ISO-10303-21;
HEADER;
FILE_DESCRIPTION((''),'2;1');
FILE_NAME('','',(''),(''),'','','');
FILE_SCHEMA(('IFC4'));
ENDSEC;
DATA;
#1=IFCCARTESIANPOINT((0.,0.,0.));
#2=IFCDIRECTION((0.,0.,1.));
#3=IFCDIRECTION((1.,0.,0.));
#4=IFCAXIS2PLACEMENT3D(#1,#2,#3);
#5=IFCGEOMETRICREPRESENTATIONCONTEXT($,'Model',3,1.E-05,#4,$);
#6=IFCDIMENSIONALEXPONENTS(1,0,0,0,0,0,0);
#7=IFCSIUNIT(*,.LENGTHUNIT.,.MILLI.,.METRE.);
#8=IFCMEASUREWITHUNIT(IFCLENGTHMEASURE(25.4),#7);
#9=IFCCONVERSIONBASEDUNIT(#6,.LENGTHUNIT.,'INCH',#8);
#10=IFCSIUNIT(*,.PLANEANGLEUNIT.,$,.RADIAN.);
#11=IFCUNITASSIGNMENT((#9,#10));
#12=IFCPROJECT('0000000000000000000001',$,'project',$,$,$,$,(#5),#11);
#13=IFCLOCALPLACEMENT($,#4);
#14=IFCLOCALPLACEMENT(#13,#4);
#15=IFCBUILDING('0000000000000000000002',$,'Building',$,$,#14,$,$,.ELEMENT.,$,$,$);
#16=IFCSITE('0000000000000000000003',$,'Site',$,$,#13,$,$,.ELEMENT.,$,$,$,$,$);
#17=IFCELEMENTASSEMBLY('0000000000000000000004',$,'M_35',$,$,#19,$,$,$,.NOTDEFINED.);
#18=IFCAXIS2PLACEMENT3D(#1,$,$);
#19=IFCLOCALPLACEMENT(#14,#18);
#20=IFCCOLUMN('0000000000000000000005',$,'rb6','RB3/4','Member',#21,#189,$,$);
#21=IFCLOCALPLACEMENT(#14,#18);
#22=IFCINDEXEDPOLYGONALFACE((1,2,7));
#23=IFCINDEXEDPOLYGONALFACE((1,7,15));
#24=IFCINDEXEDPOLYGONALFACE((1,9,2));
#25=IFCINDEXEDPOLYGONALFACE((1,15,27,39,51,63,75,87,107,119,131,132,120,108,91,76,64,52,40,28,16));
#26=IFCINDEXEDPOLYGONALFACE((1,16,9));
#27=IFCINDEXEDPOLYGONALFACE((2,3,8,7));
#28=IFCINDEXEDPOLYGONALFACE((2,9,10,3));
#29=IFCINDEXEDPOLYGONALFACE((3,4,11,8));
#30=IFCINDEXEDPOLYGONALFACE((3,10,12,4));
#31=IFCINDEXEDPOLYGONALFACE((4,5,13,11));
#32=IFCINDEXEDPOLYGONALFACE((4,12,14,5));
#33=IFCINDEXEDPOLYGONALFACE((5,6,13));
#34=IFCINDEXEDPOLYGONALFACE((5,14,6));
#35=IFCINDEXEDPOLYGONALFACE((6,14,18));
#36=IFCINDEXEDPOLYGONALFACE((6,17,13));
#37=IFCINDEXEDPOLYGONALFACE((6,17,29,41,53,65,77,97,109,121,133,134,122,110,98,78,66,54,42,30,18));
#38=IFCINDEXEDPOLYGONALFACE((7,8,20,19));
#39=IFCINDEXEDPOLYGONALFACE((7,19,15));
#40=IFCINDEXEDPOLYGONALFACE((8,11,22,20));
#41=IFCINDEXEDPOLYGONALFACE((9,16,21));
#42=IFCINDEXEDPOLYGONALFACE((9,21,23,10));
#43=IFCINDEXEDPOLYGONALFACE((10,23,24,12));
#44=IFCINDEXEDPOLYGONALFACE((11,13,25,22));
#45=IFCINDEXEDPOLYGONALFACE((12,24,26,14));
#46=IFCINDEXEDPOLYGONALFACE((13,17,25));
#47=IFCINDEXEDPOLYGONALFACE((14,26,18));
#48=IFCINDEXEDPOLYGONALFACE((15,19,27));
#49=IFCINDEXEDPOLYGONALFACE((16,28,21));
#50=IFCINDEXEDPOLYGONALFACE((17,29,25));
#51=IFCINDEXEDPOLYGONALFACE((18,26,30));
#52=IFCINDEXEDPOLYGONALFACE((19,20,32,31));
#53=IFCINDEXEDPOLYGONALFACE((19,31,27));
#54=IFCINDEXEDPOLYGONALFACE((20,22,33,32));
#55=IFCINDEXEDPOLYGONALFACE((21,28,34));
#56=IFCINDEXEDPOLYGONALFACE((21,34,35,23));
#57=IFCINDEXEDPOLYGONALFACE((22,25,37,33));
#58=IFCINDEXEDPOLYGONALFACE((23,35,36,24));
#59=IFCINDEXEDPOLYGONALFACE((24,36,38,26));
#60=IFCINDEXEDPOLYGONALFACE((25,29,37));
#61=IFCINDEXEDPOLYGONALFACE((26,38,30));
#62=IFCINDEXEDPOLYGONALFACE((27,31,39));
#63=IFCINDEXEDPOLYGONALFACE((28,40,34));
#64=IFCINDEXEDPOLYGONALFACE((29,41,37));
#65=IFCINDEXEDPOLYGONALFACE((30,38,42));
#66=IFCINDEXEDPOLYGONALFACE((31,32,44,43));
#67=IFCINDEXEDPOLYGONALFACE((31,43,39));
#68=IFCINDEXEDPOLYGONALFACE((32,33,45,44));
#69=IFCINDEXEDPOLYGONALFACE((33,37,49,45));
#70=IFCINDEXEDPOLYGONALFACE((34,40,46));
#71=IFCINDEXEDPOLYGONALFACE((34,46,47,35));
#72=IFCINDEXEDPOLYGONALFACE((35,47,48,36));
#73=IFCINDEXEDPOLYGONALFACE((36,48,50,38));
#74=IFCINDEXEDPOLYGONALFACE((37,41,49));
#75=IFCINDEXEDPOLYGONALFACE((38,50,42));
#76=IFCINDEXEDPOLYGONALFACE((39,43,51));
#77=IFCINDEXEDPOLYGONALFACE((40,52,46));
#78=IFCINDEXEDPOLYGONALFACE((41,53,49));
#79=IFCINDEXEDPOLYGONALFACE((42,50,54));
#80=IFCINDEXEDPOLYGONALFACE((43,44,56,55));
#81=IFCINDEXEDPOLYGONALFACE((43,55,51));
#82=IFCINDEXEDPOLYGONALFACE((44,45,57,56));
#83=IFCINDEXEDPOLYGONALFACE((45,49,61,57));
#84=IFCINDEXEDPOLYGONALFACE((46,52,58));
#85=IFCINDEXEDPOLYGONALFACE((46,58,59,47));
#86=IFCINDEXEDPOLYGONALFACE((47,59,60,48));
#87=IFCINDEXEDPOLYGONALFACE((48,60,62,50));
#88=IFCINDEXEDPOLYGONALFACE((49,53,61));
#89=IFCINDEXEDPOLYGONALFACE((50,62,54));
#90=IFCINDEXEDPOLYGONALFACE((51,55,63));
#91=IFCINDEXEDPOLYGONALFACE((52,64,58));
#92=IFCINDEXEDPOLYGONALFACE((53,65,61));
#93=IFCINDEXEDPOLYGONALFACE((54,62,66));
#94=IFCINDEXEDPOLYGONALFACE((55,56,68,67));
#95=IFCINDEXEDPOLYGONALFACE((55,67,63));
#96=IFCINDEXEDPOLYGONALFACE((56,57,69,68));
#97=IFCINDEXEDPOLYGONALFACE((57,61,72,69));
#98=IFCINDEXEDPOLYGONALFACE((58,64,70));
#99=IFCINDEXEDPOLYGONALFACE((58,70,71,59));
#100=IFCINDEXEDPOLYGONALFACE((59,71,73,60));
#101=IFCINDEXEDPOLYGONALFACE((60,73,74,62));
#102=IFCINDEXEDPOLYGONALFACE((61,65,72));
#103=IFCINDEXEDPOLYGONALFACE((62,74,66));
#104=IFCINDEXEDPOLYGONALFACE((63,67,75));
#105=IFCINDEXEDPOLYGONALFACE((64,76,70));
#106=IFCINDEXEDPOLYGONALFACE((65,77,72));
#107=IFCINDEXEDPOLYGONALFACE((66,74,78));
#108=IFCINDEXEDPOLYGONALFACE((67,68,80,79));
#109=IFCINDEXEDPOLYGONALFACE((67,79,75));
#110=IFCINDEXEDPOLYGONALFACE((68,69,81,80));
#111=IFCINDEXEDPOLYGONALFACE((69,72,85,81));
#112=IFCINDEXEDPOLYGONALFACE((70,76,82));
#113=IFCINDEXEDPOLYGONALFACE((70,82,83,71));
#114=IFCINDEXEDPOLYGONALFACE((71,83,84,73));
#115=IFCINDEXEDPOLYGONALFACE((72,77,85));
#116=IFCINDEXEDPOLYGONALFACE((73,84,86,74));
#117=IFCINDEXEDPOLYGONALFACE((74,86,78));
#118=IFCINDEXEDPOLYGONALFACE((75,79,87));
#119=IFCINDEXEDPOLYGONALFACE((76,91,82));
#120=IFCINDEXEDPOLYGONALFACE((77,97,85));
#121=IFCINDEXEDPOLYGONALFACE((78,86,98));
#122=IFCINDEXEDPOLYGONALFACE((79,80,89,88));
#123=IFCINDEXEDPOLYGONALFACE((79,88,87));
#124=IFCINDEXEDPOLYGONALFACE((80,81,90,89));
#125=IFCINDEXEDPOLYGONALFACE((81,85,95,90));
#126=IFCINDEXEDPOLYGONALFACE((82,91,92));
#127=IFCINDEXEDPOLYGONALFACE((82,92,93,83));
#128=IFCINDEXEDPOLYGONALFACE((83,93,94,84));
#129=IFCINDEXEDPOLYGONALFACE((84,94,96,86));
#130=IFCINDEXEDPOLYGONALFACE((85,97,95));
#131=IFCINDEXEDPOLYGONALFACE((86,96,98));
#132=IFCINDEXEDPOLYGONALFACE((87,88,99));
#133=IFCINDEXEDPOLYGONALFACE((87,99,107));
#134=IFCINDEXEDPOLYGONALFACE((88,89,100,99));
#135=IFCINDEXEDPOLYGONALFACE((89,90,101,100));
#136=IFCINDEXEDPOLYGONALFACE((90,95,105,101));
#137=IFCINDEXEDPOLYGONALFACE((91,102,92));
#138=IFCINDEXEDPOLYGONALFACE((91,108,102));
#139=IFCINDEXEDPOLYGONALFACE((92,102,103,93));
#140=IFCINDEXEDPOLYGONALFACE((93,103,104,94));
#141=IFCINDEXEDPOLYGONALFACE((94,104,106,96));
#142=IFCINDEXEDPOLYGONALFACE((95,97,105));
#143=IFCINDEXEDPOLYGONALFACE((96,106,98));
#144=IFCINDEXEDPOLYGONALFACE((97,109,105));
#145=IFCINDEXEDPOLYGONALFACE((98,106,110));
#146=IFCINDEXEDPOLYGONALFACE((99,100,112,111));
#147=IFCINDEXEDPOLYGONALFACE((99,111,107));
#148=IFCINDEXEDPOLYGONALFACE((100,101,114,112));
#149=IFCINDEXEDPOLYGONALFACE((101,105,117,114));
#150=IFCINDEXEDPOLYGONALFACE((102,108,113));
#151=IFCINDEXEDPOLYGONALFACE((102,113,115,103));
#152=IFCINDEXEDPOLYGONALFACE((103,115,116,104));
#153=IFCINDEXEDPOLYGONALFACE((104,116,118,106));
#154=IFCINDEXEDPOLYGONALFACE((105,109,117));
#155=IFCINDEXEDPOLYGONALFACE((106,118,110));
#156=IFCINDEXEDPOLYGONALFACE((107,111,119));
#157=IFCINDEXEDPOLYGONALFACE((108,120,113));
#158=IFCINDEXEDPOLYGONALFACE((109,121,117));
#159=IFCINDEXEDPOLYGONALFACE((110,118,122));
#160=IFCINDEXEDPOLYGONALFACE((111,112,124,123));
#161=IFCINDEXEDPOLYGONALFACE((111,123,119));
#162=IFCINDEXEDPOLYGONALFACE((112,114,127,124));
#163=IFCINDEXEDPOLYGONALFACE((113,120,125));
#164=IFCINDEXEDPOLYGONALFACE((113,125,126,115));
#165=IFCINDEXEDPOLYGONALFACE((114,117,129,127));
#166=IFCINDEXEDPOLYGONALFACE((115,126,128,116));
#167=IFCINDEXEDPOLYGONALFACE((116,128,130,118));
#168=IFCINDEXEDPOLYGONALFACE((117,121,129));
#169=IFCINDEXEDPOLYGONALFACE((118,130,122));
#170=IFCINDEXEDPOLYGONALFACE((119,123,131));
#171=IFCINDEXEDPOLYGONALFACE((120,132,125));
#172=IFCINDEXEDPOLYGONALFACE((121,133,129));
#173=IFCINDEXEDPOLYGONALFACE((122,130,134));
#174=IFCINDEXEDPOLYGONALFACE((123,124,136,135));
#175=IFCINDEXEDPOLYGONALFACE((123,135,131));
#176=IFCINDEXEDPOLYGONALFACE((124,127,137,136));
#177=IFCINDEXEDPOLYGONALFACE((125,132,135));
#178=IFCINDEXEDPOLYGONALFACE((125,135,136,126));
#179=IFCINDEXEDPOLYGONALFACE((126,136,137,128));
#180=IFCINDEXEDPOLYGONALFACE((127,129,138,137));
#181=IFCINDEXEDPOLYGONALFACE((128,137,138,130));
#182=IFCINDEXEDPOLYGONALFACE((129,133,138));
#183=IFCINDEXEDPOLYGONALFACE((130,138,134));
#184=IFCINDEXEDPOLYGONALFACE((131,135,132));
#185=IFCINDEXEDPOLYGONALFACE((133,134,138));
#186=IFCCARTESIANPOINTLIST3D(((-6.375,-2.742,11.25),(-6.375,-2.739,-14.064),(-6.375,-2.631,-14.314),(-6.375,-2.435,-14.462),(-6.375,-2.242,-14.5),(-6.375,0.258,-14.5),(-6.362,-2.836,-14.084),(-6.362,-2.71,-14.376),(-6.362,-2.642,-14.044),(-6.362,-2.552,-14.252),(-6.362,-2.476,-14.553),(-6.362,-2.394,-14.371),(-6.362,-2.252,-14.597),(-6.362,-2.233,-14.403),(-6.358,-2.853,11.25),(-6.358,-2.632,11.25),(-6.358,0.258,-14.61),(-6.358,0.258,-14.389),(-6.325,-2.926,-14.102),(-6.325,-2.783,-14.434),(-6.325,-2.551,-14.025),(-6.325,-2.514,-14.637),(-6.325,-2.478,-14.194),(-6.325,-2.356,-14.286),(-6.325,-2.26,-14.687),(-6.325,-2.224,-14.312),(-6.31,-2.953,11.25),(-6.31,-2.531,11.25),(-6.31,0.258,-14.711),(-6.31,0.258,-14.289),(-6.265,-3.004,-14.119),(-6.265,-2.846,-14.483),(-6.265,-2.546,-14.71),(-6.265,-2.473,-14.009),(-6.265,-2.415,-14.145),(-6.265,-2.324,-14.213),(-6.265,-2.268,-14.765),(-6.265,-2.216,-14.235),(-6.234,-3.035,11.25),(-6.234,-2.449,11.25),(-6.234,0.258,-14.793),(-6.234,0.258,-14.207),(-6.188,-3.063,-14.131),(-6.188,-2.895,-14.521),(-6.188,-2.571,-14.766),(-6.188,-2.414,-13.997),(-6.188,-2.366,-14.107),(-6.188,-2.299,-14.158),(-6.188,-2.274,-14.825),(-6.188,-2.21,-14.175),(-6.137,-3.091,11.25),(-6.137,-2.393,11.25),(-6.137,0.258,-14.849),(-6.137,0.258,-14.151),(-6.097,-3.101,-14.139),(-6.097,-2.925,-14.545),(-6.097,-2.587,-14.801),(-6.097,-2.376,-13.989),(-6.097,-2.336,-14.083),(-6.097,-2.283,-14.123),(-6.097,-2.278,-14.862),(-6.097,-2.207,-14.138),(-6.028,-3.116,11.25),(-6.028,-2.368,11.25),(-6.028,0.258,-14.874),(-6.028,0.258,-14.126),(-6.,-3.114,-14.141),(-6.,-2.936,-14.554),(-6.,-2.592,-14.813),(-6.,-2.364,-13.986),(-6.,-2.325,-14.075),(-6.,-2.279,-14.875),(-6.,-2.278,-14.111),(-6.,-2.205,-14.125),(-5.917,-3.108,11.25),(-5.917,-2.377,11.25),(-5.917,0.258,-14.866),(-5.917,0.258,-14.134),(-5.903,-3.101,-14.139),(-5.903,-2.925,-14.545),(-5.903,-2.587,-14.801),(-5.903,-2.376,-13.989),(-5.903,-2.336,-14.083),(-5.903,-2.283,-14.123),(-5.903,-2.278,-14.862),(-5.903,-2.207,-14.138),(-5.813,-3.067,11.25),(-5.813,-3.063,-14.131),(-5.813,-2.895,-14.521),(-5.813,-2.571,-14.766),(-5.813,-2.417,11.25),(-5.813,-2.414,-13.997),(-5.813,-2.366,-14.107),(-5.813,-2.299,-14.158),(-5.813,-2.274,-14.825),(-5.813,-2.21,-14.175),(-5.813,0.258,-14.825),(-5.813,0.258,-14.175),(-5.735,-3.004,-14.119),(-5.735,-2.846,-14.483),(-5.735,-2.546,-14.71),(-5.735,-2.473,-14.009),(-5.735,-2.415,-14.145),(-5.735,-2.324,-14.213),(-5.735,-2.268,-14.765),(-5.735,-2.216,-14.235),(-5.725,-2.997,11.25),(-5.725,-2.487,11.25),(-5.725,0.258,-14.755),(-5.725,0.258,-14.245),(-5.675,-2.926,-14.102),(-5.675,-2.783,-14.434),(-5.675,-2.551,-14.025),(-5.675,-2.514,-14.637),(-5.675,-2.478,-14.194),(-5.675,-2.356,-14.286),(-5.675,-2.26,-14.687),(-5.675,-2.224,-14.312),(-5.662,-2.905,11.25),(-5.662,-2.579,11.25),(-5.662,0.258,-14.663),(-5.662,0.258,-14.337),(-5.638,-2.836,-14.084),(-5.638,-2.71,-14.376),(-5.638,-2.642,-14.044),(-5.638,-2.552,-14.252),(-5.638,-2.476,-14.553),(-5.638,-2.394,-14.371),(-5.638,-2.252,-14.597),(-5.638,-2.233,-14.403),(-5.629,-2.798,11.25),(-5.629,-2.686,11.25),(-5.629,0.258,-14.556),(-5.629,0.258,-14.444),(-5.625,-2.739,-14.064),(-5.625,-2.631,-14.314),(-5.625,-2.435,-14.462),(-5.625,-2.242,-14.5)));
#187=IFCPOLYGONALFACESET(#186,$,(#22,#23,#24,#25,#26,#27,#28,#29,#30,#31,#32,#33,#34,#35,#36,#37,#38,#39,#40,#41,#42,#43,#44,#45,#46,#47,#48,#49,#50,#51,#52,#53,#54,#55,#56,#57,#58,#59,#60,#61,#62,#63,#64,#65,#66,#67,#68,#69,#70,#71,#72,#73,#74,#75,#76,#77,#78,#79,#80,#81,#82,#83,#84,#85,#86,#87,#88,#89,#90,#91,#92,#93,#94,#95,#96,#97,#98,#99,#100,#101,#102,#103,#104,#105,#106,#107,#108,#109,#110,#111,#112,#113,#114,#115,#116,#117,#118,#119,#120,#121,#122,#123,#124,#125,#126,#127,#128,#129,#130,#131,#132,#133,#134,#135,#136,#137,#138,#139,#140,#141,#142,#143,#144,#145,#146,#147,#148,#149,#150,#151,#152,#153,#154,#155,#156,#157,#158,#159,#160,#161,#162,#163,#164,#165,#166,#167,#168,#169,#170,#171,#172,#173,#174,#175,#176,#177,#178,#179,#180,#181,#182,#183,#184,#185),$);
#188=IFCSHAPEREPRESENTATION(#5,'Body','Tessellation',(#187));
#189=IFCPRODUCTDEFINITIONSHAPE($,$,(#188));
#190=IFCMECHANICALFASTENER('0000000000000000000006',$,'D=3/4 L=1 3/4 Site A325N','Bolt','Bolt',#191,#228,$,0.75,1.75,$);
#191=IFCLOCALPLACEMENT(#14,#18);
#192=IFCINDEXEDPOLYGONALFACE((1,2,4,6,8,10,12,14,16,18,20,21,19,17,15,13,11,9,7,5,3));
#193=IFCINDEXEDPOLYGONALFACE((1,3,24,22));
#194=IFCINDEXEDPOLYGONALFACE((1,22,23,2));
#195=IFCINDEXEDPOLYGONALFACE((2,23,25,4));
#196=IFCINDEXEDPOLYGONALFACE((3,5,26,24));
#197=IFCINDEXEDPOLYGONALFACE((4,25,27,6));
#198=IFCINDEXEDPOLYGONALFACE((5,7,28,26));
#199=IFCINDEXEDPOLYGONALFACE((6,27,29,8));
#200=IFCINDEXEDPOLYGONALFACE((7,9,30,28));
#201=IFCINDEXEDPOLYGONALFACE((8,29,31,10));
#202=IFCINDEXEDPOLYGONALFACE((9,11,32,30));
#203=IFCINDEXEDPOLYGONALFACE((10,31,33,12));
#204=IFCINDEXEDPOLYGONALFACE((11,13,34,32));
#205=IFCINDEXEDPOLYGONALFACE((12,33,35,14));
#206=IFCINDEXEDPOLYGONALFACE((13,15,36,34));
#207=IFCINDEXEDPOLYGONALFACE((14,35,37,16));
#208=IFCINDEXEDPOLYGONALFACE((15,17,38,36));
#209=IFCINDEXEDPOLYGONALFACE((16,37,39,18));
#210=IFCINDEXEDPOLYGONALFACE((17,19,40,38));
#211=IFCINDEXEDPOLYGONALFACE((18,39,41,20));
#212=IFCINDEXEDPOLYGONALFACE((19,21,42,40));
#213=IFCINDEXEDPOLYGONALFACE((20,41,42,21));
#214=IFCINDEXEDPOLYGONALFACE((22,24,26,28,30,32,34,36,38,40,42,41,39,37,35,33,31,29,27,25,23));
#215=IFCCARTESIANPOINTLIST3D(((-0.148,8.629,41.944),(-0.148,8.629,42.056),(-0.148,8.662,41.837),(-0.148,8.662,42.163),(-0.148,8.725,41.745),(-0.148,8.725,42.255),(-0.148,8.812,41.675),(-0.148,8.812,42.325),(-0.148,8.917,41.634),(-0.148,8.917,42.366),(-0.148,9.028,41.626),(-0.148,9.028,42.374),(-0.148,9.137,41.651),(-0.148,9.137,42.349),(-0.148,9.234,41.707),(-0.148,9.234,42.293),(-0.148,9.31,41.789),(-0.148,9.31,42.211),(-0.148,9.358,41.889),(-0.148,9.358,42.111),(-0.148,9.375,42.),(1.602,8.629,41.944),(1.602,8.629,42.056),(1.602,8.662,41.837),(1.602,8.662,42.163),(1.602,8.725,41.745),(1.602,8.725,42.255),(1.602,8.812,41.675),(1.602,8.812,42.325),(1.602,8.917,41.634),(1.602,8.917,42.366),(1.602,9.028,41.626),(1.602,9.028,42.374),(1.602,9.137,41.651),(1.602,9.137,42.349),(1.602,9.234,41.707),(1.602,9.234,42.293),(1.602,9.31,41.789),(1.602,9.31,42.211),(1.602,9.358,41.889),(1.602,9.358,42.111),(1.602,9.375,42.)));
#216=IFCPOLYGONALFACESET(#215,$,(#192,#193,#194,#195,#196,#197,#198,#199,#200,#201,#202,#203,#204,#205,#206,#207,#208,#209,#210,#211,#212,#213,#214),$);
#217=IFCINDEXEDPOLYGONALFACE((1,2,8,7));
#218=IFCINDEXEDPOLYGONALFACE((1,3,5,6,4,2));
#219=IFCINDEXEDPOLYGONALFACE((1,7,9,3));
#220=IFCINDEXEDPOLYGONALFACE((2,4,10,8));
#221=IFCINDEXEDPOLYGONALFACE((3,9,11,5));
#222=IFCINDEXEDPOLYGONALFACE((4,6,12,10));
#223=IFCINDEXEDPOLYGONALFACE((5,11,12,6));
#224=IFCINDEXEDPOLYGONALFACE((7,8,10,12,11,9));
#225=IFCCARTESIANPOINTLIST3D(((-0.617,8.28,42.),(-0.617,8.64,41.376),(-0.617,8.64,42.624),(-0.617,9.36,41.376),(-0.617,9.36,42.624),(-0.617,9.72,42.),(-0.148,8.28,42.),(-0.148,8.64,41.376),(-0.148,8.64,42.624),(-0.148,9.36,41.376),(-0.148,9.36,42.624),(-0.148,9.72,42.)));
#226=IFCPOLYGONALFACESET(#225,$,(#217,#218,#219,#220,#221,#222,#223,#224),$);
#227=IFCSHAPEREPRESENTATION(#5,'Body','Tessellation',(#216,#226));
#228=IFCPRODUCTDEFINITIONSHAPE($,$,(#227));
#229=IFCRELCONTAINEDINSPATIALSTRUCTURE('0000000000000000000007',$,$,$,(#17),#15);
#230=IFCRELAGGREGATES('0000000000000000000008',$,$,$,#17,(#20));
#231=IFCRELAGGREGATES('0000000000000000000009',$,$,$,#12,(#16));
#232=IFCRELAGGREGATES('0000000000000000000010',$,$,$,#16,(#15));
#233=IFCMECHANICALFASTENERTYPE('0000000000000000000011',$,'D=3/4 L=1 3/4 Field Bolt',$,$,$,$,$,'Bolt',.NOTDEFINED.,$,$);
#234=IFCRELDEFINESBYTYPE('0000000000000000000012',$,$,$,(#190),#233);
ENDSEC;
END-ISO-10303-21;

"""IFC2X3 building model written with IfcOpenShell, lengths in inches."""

from ifc_helpers import new_model, entity, si_unit, converted_unit, frame, origin_with_axes, origin_2d_with_axis, place, context, project, spatial, polyline, circle, outline, extrude, source, transform, mapped, type_object, type_shapes, element, aggregate, save


model = new_model("IFC2X3")

# Units and contexts
model_context = context("Model", 3, precision=1e-05, world=origin_with_axes())
ifc_project = project(units=[converted_unit("LENGTHUNIT", "INCH", entity("IfcLengthMeasure", 25.4), si_unit("LENGTHUNIT", "METRE", prefix="MILLI"), dimensions=[1, 0, 0, 0, 0, 0, 0]), si_unit("PLANEANGLEUNIT", "RADIAN")], contexts=[model_context])

# Site, building
site_placement = place(None, origin_with_axes())
site = spatial("IfcSite", under=ifc_project, at=site_placement, Name="Site", CompositionType="ELEMENT")
building_placement = place(site_placement, origin_with_axes())
building = spatial("IfcBuilding", under=site, at=building_placement, Name="Building", CompositionType="ELEMENT")

# Element assembly, column
assembly_1_placement = place(building_placement, frame((-3.0, 0.0, -22.668), z_axis=(0.0, -1.0, 0.0), x_axis=(0.0, 0.0, 1.0)))
assembly_1 = element("IfcElementAssembly", 1, at=assembly_1_placement, inside=building, Name="M_35", PredefinedType="NOTDEFINED")
column_1_placement = place(assembly_1_placement, frame((8.44, 3.0, -0.258), z_axis=(0.0, 1.0, 0.0), x_axis=(-1.0, 0.0, 0.0)))
cartesian_point_1 = entity("IfcCartesianPoint", [0.0, 0.0, 0.0])
ifc_direction_1 = entity("IfcDirection", [0.0, 0.0, 1.0])
ifc_direction_2 = entity("IfcDirection", [1.0, 0.0, 0.0])
column_1 = element("IfcColumn", 2, at=column_1_placement, Name="rb6", Description="RB3/4", ObjectType="Member", context=model_context, shape_type="SweptSolid", body=[
    entity("IfcSurfaceCurveSweptAreaSolid", entity("IfcCircleProfileDef", "AREA", None, entity("IfcAxis2Placement2D", entity("IfcCartesianPoint", [0.0, 0.0]), entity("IfcDirection", [1.0, 0.0])), 0.375), entity("IfcAxis2Placement3D", cartesian_point_1, ifc_direction_1, ifc_direction_2), entity("IfcPolyline", [entity("IfcCartesianPoint", [0.272, 0.0]), entity("IfcCartesianPoint", [0.272, 2.5]), entity("IfcCartesianPoint", [0.234, 2.693]), entity("IfcCartesianPoint", [0.086, 2.888]), entity("IfcCartesianPoint", [-0.164, 2.996]), entity("IfcCartesianPoint", [-25.478, 3.0])]), 0.0, 1.0, entity("IfcPlane", entity("IfcAxis2Placement3D", cartesian_point_1, ifc_direction_1, ifc_direction_2))),
])
aggregate(assembly_1, [column_1])

# Mechanical fastener
mechanical_fastener_type_1 = type_object("IfcMechanicalFastenerType", Name="D=3/4 L=1 3/4 Field Bolt", ElementType="Bolt")
shared_shape_1 = source(origin_with_axes(), model_context, "Body", "SweptSolid", [
    extrude(circle(Radius=0.375, at=origin_2d_with_axis()), frame((0.0, 0.0, 0.0), z_axis=(1.0, 0.0, 0.0), x_axis=(0.0, 1.0, 0.0)), (0.0, 0.0, 1.0), 1.75),
    extrude(outline(polyline([(-0.72, 0.0), (-0.36, 0.624), (0.36, 0.624), (0.72, 0.0), (0.36, -0.624), (-0.36, -0.624), (-0.72, 0.0)])), frame((0.0, 0.0, 0.0), z_axis=(1.0, 0.0, 0.0), x_axis=(0.0, 1.0, 0.0)), (0.0, 0.0, -1.0), 0.47),
])
type_shapes(mechanical_fastener_type_1, [shared_shape_1])
placement_1 = place(building_placement, frame((0.0, 0.0, 46.0), z_axis=(0.0, 0.0, 1.0), x_axis=(0.0, 1.0, 0.0)))
placement_2 = place(placement_1, frame((9.0, 0.148, -4.0), z_axis=(0.0, 0.0, 1.0), x_axis=(0.0, -1.0, 0.0)))
for number, where, z_axis, x_axis, name in (
    (3, (0.0, 0.0, 0.0), (0.0, 0.0, 1.0), (1.0, 0.0, 0.0), "D=3/4 L=1 3/4 Site A325N"),
):
    element("IfcMechanicalFastener", number, at=place(placement_2, frame(where, z_axis=z_axis, x_axis=x_axis)), type_object=mechanical_fastener_type_1, Name=name, Description="Bolt", ObjectType="Bolt", NominalDiameter=0.75, NominalLength=1.75, context=model_context, shape_type="MappedRepresentation", body=[
        mapped(shared_shape_1, transform((0.0, 0.0, 0.0), scale=1.0)),
    ])

save(model, "model.ifc")
